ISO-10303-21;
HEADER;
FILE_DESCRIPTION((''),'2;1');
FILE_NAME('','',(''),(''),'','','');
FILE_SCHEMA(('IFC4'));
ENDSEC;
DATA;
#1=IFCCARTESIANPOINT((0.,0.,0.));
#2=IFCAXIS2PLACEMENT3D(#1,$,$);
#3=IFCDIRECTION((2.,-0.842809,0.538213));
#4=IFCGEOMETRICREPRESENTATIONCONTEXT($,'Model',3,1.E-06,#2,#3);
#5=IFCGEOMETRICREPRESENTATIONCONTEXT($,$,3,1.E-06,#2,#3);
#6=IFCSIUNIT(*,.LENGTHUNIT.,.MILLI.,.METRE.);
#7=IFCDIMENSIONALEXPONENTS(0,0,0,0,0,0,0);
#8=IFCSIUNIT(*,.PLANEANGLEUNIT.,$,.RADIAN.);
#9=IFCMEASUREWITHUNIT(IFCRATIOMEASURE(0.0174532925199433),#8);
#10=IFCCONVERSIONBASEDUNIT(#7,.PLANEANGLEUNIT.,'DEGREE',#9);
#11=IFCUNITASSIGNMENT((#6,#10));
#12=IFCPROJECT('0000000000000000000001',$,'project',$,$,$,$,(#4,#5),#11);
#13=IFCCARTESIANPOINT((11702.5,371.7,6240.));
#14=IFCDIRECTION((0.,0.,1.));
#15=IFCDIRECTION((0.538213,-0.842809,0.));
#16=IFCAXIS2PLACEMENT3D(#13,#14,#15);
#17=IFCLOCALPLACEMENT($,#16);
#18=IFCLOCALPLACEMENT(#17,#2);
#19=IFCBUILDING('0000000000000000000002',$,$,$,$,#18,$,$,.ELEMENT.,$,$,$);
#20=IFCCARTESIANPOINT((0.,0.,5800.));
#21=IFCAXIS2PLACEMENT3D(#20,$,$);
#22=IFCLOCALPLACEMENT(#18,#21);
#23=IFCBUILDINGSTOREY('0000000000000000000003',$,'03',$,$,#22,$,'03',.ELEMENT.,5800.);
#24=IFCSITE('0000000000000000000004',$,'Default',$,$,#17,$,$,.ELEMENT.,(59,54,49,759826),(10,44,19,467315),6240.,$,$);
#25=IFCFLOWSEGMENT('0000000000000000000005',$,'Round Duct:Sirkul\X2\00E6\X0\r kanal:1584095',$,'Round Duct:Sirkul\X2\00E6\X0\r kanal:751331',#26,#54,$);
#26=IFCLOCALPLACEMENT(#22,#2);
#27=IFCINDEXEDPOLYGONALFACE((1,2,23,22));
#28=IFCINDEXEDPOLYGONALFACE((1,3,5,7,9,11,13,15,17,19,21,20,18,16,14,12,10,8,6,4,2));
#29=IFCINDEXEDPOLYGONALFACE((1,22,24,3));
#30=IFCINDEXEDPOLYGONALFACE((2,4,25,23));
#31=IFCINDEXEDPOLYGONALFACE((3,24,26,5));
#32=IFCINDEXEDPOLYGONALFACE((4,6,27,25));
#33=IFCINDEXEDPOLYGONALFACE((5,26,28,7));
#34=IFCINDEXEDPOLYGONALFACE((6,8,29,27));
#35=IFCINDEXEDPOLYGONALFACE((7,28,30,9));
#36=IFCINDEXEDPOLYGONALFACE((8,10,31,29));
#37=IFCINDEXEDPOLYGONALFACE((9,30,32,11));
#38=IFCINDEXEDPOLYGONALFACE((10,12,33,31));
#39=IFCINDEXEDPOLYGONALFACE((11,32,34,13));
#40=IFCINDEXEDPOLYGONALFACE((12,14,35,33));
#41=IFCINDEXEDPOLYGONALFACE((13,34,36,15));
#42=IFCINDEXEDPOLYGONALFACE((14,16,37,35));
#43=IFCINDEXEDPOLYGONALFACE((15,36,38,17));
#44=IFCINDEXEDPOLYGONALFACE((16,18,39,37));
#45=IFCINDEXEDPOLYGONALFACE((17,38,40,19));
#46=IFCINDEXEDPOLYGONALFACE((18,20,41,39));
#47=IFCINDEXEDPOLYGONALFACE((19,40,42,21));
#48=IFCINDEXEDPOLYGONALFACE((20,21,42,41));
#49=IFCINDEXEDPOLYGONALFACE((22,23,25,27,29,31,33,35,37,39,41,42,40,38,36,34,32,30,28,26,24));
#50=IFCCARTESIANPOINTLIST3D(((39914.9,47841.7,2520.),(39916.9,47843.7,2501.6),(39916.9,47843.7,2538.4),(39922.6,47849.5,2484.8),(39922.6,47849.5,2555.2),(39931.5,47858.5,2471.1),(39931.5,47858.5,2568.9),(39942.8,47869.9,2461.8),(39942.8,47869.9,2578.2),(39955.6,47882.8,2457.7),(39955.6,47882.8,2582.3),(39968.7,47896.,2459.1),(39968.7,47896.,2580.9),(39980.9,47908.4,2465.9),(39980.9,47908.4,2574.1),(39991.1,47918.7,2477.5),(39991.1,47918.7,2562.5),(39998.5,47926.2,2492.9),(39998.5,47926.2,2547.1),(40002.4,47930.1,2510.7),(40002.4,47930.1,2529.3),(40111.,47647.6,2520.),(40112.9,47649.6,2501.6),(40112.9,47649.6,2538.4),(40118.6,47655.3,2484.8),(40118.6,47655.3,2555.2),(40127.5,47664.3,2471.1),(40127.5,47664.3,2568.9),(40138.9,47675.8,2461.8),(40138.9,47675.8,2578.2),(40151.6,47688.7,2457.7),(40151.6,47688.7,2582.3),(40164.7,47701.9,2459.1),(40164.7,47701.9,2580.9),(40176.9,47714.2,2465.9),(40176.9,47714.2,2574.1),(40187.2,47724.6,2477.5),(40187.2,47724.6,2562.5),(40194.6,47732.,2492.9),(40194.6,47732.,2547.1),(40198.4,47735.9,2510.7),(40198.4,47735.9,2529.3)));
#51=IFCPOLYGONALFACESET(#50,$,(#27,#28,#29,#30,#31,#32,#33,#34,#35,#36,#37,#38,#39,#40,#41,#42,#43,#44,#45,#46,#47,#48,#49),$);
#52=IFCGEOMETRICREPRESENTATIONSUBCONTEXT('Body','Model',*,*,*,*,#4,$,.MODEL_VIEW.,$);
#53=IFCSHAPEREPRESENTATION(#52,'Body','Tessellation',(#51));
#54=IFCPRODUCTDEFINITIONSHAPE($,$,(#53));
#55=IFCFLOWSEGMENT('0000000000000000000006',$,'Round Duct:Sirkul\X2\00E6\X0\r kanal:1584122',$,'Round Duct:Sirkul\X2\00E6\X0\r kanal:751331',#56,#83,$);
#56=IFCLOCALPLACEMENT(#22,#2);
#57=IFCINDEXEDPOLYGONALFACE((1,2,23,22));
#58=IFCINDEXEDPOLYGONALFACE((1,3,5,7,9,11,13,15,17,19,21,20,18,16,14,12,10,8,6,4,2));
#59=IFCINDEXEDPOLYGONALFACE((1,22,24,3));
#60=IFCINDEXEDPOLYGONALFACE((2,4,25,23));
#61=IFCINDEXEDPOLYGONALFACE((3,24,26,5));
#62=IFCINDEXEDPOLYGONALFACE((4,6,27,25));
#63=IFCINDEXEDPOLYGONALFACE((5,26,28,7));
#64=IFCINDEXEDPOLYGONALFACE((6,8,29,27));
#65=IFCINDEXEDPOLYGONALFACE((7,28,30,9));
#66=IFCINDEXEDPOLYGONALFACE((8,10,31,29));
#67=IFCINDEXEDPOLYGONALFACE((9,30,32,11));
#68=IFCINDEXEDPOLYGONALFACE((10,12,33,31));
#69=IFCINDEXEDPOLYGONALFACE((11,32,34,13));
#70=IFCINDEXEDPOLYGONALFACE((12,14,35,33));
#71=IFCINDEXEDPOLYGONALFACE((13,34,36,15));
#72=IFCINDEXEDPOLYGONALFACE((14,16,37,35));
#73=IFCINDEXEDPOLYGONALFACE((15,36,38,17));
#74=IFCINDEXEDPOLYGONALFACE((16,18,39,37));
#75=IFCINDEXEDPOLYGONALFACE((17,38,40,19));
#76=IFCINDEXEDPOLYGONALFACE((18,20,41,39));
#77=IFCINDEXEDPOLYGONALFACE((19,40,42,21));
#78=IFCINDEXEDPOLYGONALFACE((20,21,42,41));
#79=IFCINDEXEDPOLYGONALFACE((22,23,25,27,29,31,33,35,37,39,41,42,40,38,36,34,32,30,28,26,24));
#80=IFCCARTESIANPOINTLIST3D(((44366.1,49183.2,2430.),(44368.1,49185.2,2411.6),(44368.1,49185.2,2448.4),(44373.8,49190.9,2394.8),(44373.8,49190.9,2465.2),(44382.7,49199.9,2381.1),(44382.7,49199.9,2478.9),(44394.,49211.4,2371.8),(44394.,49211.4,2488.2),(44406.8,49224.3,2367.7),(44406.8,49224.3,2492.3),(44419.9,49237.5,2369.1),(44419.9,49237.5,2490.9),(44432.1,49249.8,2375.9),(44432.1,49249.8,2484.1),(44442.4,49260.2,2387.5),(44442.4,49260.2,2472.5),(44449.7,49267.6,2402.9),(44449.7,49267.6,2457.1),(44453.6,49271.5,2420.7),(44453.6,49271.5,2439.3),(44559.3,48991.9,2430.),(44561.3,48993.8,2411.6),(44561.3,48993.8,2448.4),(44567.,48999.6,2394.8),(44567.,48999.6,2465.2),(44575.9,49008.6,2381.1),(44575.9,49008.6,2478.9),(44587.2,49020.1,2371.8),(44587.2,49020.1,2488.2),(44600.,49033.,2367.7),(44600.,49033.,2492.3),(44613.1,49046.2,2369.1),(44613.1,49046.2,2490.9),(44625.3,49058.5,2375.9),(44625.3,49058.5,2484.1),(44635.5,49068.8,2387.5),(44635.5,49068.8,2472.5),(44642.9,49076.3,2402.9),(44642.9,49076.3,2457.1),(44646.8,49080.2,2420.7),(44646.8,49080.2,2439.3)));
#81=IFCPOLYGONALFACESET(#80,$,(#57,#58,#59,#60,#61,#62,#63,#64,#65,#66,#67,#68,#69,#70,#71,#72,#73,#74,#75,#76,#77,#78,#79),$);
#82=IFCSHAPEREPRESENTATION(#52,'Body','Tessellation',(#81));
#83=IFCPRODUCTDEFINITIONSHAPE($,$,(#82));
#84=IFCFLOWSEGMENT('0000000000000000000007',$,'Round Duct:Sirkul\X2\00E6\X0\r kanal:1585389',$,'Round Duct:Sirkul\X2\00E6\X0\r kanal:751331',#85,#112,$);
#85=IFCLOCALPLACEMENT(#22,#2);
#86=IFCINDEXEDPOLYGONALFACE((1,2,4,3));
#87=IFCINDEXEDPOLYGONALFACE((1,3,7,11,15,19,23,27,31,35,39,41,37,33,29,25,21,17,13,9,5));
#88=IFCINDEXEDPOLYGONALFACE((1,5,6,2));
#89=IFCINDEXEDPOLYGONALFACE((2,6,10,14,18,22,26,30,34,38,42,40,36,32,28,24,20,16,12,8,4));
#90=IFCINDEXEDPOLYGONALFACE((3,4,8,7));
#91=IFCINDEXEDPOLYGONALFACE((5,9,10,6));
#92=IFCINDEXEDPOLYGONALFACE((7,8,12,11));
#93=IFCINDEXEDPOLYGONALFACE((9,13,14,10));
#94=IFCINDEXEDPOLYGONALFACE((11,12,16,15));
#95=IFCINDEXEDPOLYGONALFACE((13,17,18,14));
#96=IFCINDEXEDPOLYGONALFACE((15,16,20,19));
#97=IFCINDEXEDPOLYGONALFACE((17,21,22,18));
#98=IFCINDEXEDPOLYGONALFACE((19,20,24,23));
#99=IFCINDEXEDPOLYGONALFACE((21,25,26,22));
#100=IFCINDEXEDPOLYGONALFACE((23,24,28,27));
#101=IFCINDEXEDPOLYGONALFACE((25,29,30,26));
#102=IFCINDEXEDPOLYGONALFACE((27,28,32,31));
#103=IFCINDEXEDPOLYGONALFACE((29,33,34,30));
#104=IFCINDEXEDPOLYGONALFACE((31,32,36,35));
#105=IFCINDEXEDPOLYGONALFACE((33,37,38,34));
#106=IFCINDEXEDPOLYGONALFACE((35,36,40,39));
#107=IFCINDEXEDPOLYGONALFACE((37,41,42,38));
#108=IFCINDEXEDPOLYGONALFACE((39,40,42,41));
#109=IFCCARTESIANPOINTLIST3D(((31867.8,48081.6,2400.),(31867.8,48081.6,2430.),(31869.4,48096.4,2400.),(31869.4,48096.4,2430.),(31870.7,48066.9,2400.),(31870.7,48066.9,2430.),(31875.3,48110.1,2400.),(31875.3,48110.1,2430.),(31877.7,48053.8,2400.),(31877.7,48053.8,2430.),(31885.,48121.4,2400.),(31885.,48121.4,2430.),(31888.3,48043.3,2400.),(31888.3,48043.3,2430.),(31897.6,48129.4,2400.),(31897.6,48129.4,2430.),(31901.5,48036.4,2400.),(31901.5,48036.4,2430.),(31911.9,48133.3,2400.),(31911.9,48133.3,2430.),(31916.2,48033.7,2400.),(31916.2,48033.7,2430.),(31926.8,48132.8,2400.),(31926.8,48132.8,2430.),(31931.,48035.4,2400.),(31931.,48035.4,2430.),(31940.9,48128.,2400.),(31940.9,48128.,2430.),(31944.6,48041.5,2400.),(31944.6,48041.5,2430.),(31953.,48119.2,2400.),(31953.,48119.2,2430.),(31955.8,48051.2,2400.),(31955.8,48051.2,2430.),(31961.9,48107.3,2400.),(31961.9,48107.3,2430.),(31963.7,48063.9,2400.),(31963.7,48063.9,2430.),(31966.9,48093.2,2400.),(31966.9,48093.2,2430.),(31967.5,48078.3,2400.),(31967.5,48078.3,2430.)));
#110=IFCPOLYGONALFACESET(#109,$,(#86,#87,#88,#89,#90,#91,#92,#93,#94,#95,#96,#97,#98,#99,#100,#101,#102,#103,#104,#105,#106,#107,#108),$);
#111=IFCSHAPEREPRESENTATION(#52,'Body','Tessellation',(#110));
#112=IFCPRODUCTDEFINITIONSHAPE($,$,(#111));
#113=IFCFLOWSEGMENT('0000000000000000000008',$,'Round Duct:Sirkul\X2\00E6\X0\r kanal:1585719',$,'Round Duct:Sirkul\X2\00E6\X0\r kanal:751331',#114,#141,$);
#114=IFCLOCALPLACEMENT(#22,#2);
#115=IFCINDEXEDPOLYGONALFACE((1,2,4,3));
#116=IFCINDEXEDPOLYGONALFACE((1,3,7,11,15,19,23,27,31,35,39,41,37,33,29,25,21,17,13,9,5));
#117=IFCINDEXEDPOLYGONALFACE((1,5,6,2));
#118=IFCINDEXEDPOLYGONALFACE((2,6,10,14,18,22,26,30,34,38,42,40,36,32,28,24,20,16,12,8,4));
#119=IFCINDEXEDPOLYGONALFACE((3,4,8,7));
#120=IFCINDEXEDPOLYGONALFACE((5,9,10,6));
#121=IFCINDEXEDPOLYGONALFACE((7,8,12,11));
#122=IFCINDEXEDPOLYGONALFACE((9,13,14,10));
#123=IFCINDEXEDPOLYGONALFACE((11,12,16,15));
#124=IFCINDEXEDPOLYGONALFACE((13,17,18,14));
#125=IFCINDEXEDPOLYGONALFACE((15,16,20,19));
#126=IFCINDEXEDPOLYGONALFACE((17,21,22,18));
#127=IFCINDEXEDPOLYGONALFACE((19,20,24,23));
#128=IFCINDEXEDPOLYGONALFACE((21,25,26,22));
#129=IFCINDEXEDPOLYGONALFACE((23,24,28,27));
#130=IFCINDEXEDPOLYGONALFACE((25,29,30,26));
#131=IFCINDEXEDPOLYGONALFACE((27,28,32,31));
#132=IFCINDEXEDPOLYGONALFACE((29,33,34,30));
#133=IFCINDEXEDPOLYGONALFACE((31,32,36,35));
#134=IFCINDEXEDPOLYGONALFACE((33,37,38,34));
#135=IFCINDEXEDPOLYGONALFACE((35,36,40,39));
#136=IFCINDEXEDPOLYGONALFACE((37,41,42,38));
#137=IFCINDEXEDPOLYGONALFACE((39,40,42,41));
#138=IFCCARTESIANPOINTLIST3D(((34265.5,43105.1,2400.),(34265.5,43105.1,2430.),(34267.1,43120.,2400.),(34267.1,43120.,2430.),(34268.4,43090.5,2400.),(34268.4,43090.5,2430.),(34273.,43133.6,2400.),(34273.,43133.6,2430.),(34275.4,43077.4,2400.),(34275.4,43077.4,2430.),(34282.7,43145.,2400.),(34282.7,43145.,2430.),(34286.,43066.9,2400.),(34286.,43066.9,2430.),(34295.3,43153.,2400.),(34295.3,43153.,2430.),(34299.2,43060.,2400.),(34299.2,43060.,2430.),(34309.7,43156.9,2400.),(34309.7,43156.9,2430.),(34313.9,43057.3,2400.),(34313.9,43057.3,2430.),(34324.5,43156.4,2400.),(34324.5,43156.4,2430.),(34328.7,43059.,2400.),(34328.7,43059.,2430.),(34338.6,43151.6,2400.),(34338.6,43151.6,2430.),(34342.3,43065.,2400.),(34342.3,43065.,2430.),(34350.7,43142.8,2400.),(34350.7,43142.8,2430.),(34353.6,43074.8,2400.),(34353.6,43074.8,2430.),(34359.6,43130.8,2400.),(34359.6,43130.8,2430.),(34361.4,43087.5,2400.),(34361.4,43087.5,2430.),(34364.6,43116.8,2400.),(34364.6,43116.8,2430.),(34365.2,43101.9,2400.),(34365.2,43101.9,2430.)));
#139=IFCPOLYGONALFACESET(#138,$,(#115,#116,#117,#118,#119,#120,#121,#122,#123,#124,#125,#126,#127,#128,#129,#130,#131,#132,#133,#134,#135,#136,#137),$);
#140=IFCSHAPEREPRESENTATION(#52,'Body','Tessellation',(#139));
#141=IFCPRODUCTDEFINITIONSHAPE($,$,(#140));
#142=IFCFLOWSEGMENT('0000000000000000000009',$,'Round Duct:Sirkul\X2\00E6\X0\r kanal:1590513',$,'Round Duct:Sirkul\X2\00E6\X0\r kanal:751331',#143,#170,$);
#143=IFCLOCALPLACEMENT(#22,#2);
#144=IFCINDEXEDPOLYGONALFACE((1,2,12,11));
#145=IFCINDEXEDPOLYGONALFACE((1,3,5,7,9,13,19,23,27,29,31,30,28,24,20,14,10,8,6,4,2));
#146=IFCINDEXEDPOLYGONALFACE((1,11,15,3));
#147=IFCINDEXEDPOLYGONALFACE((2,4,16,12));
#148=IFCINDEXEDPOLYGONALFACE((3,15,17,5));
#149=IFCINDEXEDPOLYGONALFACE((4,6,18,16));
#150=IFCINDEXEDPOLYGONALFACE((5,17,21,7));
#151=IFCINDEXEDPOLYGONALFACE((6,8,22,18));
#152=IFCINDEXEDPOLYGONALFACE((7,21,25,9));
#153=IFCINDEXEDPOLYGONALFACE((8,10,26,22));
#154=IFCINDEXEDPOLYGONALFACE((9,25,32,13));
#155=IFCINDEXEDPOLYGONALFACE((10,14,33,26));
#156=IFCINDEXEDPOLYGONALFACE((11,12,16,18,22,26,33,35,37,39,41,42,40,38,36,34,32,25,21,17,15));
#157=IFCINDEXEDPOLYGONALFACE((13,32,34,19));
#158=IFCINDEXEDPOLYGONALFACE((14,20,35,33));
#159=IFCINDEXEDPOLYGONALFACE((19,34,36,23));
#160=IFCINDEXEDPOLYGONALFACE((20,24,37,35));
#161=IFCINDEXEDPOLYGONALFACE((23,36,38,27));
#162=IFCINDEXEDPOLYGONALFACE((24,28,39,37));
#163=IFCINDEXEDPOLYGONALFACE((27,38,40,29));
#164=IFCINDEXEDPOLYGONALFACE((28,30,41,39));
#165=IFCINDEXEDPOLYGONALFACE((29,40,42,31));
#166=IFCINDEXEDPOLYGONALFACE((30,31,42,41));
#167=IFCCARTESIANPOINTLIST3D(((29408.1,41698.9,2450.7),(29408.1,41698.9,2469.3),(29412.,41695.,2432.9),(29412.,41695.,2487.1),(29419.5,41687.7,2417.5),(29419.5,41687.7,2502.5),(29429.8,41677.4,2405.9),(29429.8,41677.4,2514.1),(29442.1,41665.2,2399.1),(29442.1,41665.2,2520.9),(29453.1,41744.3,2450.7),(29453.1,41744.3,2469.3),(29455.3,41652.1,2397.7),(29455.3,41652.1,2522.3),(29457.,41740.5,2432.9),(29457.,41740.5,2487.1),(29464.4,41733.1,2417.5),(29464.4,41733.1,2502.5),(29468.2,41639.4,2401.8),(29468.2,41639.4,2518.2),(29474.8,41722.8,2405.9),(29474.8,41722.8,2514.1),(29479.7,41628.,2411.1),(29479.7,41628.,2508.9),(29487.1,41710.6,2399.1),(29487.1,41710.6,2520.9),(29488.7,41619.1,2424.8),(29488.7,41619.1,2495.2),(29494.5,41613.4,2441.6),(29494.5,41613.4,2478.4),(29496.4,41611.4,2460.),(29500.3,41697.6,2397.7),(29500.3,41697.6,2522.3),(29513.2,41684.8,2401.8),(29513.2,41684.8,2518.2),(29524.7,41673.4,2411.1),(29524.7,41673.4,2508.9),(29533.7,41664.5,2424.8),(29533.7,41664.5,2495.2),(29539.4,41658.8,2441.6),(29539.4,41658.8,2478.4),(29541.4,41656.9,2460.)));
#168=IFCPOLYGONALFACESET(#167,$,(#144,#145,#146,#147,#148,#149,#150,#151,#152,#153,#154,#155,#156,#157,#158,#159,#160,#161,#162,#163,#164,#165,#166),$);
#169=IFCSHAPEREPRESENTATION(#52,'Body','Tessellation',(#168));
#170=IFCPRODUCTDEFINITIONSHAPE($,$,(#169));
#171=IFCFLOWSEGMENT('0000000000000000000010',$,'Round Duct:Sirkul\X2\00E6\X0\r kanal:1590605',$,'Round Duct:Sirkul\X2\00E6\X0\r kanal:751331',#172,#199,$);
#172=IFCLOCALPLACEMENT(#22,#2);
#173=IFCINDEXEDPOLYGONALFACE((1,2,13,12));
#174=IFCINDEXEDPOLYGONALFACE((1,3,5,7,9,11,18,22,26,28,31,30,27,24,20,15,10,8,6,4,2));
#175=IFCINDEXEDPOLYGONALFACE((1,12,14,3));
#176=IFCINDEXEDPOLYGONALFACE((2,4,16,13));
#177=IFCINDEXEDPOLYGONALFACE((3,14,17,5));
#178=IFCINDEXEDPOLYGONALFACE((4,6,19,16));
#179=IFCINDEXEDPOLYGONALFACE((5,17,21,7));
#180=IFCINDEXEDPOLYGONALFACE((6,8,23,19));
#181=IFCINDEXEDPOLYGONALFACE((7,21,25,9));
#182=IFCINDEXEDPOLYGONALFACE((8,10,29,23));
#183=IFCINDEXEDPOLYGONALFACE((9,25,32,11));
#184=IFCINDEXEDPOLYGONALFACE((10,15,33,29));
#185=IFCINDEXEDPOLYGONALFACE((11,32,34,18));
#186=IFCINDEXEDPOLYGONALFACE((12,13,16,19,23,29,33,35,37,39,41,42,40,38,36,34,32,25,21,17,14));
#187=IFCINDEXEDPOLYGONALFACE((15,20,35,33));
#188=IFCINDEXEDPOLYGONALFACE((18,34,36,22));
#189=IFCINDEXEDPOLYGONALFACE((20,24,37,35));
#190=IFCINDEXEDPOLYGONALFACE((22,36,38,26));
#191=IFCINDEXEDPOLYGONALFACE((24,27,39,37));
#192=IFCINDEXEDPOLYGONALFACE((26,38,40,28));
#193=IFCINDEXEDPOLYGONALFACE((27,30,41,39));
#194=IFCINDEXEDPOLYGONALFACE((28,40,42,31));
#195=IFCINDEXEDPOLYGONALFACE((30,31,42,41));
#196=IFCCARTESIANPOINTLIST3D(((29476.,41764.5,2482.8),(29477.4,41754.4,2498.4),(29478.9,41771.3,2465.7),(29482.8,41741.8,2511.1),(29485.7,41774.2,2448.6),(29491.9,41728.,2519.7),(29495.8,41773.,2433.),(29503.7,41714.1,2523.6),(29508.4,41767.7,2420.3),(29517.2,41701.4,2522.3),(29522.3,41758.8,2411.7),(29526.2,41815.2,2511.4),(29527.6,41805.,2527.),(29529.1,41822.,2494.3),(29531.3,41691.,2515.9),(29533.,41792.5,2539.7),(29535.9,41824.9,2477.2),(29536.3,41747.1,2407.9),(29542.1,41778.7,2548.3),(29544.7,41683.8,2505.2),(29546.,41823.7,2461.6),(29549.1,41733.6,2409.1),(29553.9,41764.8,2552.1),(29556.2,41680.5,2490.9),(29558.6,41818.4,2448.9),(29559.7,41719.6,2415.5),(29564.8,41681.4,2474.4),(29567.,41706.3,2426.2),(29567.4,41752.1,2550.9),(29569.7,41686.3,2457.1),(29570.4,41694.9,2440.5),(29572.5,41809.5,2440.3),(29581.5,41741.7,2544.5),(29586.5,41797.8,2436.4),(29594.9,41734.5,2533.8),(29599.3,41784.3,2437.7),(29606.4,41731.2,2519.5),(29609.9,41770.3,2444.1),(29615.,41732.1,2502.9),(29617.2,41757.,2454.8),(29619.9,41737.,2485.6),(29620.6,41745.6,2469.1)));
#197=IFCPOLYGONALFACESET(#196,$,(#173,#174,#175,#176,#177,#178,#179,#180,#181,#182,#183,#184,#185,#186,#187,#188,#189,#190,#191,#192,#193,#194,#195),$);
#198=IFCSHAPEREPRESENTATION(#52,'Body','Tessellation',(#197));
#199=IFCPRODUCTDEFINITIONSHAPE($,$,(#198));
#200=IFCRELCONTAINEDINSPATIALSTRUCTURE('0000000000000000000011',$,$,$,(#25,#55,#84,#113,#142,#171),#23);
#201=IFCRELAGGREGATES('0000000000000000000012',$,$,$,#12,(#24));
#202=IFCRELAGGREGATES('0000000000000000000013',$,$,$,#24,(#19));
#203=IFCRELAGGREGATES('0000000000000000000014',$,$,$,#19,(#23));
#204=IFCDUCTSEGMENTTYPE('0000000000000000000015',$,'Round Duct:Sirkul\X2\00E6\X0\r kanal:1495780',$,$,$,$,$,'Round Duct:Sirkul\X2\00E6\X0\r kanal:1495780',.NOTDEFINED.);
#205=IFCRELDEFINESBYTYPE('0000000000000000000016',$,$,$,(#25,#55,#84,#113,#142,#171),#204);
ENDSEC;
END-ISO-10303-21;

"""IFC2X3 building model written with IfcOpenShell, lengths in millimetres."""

from ifc_helpers import new_model, entity, si_unit, converted_unit, direction, frame, frame_2d, origin, origin_2d_with_axis, place, context, subcontext, project, spatial, circle, extrude, type_object, element, save


model = new_model("IFC2X3")

# Units and contexts
model_context = context("Model", 3, precision=1e-06, world=origin(), true_north=direction((2.0, -0.842809, 0.538213)))
context_of_model = context(None, 3, precision=1e-06, world=origin(), true_north=direction((2.0, -0.842809, 0.538213)))
body_context = subcontext(model_context, "Body", "Model", "MODEL_VIEW")
ifc_project = project(units=[si_unit("LENGTHUNIT", "METRE", prefix="MILLI"), converted_unit("PLANEANGLEUNIT", "DEGREE", entity("IfcRatioMeasure", 0.0174532925199433), si_unit("PLANEANGLEUNIT", "RADIAN"), dimensions=[0, 0, 0, 0, 0, 0, 0])], contexts=[model_context, context_of_model])

# Site, building, storey
site_placement = place(None, frame((11702.5, 371.7, 6240.0), z_axis=(0.0, 0.0, 1.0), x_axis=(0.538213, -0.842809, 0.0)))
site = spatial("IfcSite", under=ifc_project, at=site_placement, Name="Default", CompositionType="ELEMENT", RefLatitude=(59, 54, 49, 759826), RefLongitude=(10, 44, 19, 467315), RefElevation=6240.0)
building_placement = place(site_placement, origin())
building = spatial("IfcBuilding", under=site, at=building_placement, CompositionType="ELEMENT")
storey_placement = place(building_placement, frame((0.0, 0.0, 5800.0)))
storey = spatial("IfcBuildingStorey", under=building, at=storey_placement, Name="03", LongName="03", CompositionType="ELEMENT", Elevation=5800.0)

# Flow segments
duct_segment_type = type_object("IfcDuctSegmentType", Name="Round Duct:Sirkulær kanal:1495780", ElementType="Round Duct:Sirkulær kanal:1495780", PredefinedType="NOTDEFINED")
flow_segment_1_placement = place(storey_placement, origin())
element("IfcFlowSegment", 1, at=flow_segment_1_placement, inside=storey, type_object=duct_segment_type, Name="Round Duct:Sirkulær kanal:1584095", ObjectType="Round Duct:Sirkulær kanal:751331", context=body_context, shape_type="SweptSolid", body=[
    extrude(circle(Radius=62.5, at=frame_2d((0.0, 0.0), x_axis=(1.0, 0.0))), frame((40154.9, 47692.0, 2520.0), z_axis=(-0.710554, 0.703643, 0.0), x_axis=(-0.703643, -0.710554, 0.0)), (0.0, 0.0, 1.0), 275.9),
])
flow_segment_2_placement = place(storey_placement, origin())
element("IfcFlowSegment", 2, at=flow_segment_2_placement, inside=storey, type_object=duct_segment_type, Name="Round Duct:Sirkulær kanal:1584122", ObjectType="Round Duct:Sirkulær kanal:751331", context=body_context, shape_type="SweptSolid", body=[
    extrude(circle(Radius=62.5, at=origin_2d_with_axis()), frame((44410.1, 49227.6, 2430.0), z_axis=(0.710528, -0.703669, 0.0), x_axis=(-0.703669, -0.710528, 0.0)), (0.0, 0.0, 1.0), 271.9),
])
flow_segment_3_placement = place(storey_placement, origin())
element("IfcFlowSegment", 3, at=flow_segment_3_placement, inside=storey, type_object=duct_segment_type, Name="Round Duct:Sirkulær kanal:1585389", ObjectType="Round Duct:Sirkulær kanal:751331", context=body_context, shape_type="SweptSolid", body=[
    extrude(circle(Radius=50.0, at=frame_2d((0.0, 0.0), x_axis=(1.0, 0.0))), frame((31917.8, 48083.7, 2400.0), z_axis=(0.0, 0.0, 1.0), x_axis=(0.703643, 0.710554, 0.0)), (0.0, 0.0, 1.0), 30.0),
])
flow_segment_4_placement = place(storey_placement, origin())
element("IfcFlowSegment", 4, at=flow_segment_4_placement, inside=storey, type_object=duct_segment_type, Name="Round Duct:Sirkulær kanal:1585719", ObjectType="Round Duct:Sirkulær kanal:751331", context=body_context, shape_type="SweptSolid", body=[
    extrude(circle(Radius=50.0, at=frame_2d((0.0, 0.0), x_axis=(1.0, 0.0))), frame((34315.5, 43107.2, 2400.0), z_axis=(0.0, 0.0, 1.0), x_axis=(0.703643, 0.710554, 0.0)), (0.0, 0.0, 1.0), 30.0),
])
flow_segment_5_placement = place(storey_placement, origin())
element("IfcFlowSegment", 5, at=flow_segment_5_placement, inside=storey, type_object=duct_segment_type, Name="Round Duct:Sirkulær kanal:1590513", ObjectType="Round Duct:Sirkulær kanal:751331", context=body_context, shape_type="SweptSolid", body=[
    extrude(circle(Radius=62.5, at=frame_2d((0.0, 0.0), x_axis=(1.0, 0.0))), frame((29452.0, 41655.4, 2460.0), z_axis=(0.703643, 0.710554, 0.0), x_axis=(0.710554, -0.703643, 0.0)), (0.0, 0.0, 1.0), 63.9),
])
flow_segment_6_placement = place(storey_placement, origin())
element("IfcFlowSegment", 6, at=flow_segment_6_placement, inside=storey, type_object=duct_segment_type, Name="Round Duct:Sirkulær kanal:1590605", ObjectType="Round Duct:Sirkulær kanal:751331", context=body_context, shape_type="SweptSolid", body=[
    extrude(circle(Radius=62.5, at=frame_2d((0.0, 0.0), x_axis=(1.0, 0.0))), frame((29523.3, 41727.3, 2465.7), z_axis=(0.653126, 0.659597, 0.371966), x_axis=(-0.710584, 0.703612, 0.0)), (0.0, 0.0, 1.0), 76.9),
])

save(model, "model.ifc")
